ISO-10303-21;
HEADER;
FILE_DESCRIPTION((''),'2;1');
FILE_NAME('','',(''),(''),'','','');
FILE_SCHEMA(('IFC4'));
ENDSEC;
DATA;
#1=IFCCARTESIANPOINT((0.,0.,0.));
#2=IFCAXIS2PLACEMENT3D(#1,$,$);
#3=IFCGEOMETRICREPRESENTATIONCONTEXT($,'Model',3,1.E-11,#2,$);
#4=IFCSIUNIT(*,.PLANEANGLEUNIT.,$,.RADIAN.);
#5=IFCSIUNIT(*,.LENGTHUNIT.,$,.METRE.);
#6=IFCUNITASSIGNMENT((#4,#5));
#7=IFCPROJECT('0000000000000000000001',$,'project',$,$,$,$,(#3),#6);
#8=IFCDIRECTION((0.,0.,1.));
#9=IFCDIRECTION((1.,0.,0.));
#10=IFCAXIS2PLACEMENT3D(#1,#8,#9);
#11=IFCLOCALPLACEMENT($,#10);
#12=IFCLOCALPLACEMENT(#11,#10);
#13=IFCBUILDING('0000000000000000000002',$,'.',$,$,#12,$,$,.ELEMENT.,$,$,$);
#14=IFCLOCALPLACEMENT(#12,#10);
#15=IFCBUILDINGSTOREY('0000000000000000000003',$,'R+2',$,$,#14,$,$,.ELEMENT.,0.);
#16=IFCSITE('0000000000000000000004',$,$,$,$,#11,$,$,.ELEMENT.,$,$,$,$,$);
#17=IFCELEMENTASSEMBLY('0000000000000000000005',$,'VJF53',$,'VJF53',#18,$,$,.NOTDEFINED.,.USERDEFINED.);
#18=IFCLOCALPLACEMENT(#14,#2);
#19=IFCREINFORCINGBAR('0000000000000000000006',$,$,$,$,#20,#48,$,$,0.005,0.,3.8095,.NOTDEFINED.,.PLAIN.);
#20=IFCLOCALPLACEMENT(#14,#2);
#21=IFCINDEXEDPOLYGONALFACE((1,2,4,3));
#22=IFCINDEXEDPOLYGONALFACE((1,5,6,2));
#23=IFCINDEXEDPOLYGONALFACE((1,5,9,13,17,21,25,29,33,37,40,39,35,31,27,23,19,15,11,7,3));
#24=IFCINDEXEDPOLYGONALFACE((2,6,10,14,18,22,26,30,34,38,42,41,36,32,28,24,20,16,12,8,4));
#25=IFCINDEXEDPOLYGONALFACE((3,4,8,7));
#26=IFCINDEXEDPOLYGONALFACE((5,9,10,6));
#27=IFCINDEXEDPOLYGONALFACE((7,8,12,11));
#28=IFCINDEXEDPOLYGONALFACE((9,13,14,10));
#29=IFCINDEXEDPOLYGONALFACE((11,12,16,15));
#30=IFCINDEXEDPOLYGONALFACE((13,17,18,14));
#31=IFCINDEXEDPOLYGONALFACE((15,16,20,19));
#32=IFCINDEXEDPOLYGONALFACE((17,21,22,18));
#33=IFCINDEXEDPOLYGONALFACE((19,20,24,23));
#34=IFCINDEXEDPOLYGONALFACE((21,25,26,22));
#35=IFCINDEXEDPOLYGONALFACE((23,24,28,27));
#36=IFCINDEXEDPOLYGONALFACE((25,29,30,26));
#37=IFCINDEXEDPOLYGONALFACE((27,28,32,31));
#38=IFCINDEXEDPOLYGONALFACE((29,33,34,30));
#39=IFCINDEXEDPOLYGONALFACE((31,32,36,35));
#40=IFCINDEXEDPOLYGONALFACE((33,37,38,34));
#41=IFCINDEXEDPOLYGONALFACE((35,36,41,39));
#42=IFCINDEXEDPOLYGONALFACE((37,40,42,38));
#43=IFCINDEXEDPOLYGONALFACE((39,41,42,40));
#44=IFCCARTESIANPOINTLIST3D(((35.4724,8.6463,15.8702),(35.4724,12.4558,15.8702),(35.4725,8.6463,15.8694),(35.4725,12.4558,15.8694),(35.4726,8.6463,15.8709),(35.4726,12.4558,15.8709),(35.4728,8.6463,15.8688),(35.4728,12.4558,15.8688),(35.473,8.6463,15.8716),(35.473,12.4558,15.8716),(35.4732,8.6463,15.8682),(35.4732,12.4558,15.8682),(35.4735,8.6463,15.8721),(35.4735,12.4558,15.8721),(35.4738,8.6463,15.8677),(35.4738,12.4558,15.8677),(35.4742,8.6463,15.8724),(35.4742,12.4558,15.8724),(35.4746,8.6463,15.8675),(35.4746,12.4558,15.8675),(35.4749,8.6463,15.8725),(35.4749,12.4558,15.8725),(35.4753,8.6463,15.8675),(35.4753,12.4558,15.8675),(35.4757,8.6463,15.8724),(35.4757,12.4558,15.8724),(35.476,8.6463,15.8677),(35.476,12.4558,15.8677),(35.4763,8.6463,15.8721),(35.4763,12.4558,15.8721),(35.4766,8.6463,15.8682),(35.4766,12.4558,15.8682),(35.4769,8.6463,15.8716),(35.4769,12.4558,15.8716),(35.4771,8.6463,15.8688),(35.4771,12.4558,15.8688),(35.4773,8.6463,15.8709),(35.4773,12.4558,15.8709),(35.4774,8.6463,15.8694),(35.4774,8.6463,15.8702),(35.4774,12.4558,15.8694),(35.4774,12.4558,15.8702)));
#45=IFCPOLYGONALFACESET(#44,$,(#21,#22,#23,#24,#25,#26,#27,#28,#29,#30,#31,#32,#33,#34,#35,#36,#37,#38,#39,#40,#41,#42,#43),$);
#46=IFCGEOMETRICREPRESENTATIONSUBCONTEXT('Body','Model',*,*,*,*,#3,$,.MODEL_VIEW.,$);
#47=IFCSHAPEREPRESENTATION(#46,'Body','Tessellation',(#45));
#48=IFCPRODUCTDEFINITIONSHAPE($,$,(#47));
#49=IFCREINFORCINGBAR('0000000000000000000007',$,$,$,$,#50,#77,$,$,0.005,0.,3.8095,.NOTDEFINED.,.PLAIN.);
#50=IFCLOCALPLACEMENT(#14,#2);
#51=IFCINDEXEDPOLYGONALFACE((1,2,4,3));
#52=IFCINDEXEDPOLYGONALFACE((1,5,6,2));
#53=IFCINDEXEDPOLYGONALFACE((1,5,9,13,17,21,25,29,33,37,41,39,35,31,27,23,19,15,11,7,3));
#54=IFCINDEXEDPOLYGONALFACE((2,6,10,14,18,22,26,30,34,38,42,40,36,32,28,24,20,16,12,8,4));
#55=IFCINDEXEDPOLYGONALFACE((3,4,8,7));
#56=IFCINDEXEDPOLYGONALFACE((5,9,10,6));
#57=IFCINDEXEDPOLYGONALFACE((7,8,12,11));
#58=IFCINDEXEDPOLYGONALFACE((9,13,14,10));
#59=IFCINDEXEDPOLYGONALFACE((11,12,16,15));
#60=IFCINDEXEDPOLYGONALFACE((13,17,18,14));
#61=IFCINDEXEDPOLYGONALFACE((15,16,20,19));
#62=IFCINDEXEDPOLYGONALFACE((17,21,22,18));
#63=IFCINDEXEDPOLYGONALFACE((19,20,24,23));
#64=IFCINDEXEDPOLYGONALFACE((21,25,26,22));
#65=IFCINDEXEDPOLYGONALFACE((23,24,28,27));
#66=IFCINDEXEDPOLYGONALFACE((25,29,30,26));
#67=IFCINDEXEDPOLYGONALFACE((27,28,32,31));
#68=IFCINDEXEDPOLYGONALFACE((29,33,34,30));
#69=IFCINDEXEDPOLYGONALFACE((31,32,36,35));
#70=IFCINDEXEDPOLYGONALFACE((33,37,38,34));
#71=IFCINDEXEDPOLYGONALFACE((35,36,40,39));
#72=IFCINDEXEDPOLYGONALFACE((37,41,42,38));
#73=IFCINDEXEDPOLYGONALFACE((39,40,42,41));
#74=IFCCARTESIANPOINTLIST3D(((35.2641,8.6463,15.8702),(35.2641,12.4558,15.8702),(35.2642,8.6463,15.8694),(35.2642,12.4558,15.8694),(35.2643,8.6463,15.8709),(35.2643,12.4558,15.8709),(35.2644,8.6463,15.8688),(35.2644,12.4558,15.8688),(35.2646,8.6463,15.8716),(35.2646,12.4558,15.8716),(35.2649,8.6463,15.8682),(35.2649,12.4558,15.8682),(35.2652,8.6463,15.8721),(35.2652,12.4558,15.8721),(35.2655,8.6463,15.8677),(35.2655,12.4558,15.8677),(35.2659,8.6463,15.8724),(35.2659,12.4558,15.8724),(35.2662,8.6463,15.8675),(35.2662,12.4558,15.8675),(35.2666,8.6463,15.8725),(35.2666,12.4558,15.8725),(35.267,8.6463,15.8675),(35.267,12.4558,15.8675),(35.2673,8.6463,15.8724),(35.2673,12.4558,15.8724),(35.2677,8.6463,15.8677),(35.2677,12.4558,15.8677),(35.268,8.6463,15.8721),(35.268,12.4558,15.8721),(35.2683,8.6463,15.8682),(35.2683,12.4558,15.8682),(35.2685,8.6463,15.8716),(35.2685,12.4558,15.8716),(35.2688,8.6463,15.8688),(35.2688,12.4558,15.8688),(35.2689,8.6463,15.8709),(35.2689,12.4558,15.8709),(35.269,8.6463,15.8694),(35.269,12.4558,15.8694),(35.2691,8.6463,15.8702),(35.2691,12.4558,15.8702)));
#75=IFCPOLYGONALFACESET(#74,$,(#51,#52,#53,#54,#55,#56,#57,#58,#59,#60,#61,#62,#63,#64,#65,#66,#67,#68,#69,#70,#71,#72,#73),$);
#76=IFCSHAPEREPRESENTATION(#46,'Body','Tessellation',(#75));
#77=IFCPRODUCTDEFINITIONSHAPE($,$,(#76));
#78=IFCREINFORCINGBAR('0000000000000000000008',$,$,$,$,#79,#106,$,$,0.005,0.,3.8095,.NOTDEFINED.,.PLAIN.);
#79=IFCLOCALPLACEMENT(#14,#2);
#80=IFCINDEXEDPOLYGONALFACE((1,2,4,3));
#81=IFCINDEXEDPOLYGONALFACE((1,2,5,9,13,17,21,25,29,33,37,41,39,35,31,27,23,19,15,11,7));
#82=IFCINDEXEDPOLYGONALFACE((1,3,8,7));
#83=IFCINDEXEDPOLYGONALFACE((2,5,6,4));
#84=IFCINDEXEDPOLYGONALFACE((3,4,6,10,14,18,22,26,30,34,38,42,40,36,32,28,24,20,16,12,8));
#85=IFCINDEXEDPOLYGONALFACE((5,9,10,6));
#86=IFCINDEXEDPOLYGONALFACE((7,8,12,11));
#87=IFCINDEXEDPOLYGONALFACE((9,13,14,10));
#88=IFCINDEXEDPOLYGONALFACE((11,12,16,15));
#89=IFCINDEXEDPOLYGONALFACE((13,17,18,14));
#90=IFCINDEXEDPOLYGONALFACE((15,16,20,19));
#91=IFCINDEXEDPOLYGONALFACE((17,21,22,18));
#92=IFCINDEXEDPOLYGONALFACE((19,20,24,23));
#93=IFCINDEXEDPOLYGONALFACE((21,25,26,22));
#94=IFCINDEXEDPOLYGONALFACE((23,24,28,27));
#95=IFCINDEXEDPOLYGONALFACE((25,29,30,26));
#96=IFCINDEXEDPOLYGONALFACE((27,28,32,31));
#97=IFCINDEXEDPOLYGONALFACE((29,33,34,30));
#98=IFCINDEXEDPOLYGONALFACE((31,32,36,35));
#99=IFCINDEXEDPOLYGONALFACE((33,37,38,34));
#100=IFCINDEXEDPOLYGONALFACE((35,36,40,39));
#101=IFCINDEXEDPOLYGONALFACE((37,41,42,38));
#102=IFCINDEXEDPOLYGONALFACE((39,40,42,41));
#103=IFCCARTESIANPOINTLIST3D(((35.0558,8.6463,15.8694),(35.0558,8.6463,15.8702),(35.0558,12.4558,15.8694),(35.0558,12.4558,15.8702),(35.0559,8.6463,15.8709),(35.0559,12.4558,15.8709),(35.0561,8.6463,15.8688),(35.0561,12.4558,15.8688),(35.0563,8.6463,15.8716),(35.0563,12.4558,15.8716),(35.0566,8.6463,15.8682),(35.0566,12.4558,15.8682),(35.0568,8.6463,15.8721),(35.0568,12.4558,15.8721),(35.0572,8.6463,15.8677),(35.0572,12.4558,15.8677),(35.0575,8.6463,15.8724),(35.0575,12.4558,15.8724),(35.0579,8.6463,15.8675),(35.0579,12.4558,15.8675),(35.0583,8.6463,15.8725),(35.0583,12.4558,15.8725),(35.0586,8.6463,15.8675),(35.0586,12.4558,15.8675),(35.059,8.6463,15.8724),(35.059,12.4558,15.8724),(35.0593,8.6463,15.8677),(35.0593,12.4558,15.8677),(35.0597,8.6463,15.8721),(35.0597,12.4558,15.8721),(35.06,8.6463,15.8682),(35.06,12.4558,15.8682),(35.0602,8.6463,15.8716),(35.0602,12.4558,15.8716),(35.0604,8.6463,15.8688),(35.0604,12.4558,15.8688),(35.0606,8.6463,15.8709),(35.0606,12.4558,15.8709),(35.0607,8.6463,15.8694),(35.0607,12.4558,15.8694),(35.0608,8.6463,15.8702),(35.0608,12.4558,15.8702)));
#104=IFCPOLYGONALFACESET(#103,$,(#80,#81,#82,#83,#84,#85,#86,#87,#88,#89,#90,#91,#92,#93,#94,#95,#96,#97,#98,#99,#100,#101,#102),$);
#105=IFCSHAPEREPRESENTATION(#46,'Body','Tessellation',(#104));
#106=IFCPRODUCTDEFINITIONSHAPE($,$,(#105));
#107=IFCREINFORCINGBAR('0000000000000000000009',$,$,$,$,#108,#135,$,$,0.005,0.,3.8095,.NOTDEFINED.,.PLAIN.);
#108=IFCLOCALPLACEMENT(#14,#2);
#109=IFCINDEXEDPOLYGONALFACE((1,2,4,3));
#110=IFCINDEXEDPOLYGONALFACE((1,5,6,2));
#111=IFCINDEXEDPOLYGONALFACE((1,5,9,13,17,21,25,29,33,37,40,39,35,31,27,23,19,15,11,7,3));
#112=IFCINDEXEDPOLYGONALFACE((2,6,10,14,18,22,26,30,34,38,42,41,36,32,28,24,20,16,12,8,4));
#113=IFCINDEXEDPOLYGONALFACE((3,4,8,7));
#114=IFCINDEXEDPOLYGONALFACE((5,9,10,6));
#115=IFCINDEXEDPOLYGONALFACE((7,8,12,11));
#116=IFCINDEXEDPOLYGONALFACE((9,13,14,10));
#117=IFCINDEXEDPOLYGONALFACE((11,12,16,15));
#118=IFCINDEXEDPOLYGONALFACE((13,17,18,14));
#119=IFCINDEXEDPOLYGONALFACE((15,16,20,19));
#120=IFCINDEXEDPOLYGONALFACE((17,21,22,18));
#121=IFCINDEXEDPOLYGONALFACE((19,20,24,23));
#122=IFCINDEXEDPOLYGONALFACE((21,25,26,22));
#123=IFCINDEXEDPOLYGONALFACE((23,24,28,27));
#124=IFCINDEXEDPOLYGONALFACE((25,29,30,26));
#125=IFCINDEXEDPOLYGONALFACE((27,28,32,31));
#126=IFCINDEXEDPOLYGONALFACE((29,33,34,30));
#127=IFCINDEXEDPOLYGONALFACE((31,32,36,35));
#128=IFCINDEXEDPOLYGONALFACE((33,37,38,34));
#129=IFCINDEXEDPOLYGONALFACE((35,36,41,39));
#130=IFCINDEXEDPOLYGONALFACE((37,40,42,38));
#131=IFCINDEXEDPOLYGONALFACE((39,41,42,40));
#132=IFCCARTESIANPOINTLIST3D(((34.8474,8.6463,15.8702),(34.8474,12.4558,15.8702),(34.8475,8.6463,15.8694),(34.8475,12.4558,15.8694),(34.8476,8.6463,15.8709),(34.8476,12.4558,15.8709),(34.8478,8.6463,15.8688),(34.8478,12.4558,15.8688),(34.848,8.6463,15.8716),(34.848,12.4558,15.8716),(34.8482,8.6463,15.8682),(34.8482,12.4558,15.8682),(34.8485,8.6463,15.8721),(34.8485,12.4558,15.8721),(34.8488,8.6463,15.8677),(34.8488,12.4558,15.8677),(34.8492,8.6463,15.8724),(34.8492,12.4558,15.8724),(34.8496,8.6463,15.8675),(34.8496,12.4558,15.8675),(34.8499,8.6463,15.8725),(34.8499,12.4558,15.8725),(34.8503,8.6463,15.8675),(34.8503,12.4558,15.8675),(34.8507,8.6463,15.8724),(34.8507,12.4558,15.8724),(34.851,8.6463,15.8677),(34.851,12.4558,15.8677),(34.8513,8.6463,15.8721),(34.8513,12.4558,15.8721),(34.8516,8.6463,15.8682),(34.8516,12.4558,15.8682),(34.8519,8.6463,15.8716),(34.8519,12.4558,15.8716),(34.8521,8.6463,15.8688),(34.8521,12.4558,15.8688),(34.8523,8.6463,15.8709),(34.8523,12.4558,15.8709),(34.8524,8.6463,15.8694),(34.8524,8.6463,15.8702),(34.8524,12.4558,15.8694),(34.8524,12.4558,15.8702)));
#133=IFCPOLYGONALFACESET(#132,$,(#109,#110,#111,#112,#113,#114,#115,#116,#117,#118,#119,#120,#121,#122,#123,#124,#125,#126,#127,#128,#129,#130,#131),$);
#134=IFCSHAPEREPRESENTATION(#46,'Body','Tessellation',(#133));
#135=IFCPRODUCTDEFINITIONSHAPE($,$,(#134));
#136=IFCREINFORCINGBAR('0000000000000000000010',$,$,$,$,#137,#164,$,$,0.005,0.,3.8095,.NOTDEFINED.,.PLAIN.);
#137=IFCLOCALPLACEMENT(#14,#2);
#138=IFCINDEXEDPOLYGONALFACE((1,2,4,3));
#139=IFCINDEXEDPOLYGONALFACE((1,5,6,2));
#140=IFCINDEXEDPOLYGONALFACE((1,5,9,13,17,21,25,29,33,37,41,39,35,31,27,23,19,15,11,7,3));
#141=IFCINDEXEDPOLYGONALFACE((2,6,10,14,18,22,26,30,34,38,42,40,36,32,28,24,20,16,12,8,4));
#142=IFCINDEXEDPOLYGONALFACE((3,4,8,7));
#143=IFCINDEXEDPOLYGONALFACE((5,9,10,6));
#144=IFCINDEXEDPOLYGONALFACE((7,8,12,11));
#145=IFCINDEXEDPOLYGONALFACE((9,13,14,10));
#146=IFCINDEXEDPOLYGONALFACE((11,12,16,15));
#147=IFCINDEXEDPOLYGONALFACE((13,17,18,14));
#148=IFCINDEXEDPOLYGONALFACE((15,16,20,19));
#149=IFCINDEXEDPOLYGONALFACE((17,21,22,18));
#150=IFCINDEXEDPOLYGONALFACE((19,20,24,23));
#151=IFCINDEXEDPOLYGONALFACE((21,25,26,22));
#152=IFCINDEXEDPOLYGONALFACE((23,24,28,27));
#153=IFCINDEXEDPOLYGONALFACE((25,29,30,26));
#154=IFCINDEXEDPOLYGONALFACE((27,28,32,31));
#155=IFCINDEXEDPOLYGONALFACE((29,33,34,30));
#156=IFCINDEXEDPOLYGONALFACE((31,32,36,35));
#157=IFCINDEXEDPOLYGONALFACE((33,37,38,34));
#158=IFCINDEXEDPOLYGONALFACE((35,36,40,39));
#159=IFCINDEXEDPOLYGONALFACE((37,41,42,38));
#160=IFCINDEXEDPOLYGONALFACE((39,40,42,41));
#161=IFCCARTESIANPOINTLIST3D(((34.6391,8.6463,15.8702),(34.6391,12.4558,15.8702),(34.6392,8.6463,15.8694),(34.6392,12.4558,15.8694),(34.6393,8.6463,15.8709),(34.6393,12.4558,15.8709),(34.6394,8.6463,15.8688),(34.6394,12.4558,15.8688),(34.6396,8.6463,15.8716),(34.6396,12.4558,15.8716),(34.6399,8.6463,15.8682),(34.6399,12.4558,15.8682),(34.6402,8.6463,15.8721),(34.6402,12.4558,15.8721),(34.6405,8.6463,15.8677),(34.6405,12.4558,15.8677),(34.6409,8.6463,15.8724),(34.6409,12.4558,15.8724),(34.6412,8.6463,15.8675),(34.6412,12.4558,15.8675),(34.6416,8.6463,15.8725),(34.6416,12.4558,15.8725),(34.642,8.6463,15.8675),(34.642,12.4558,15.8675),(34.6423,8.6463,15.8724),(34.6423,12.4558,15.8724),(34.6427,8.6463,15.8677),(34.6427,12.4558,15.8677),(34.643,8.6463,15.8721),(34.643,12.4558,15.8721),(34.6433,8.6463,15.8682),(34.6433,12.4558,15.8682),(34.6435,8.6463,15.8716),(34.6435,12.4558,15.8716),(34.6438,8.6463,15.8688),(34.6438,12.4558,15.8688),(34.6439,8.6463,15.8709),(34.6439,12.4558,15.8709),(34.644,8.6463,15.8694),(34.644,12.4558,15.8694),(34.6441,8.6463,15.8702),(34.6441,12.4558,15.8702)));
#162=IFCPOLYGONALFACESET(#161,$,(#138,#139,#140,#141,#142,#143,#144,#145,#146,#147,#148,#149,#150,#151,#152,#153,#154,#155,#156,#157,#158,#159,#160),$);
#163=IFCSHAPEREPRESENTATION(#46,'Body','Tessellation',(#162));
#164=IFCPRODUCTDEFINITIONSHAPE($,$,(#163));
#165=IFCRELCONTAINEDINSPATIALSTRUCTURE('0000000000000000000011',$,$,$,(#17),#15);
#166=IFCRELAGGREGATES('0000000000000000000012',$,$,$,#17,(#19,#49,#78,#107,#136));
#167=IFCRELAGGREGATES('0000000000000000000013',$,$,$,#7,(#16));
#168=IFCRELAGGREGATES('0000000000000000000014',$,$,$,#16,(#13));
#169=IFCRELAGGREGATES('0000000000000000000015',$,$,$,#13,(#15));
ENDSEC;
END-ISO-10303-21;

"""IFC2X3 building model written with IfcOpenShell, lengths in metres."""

from ifc_helpers import new_model, entity, si_unit, origin, origin_with_axes, place, context, subcontext, project, spatial, shape, element, aggregate, save


model = new_model("IFC2X3")

# Units and contexts
model_context = context("Model", 3, precision=1e-11, world=origin())
body_context = subcontext(model_context, "Body", "Model", "MODEL_VIEW")
ifc_project = project(units=[si_unit("PLANEANGLEUNIT", "RADIAN"), si_unit("LENGTHUNIT", "METRE")], contexts=[model_context])

# Site, building, storey
site_placement = place(None, origin_with_axes())
site = spatial("IfcSite", under=ifc_project, at=site_placement, CompositionType="ELEMENT")
building_placement = place(site_placement, origin_with_axes())
building = spatial("IfcBuilding", under=site, at=building_placement, Name=".", CompositionType="ELEMENT")
storey_placement = place(building_placement, origin_with_axes())
storey = spatial("IfcBuildingStorey", under=building, at=storey_placement, Name="R+2", CompositionType="ELEMENT", Elevation=0.0)

# Element assembly, reinforcing bars
assembly_1_placement = place(storey_placement, origin_with_axes())
assembly_1 = element("IfcElementAssembly", 1, at=assembly_1_placement, inside=storey, Name="VJF53", ObjectType="VJF53", AssemblyPlace="NOTDEFINED", PredefinedType="USERDEFINED")
reinforcing_bar_1_placement = place(assembly_1_placement, origin_with_axes())
reinforcing_bar_1 = element("IfcReinforcingBar", 2, at=reinforcing_bar_1_placement, BarLength=3.8095, BarRole="NOTDEFINED", BarSurface="PLAIN", CrossSectionArea=0.0, NominalDiameter=0.005, shapes=[
    shape(body_context, "Body", "AdvancedSweptSolid", [entity("IfcSweptDiskSolid", entity("IfcPolyline", [entity("IfcCartesianPoint", [35.4749, 8.6463, 15.87]), entity("IfcCartesianPoint", [35.4749, 12.4558, 15.87])]), 0.0025, None, 0.0, 3.8095)]),
    shape(body_context, "Body", "AdvancedSweptSolid", [entity("IfcSweptDiskSolid", entity("IfcPolyline", [entity("IfcCartesianPoint", [35.4749, 8.6463, 15.87]), entity("IfcCartesianPoint", [35.4749, 12.4558, 15.87])]), 0.0025, None, 0.0, 3.8095)]),
])
reinforcing_bar_2_placement = place(assembly_1_placement, origin_with_axes())
reinforcing_bar_2 = element("IfcReinforcingBar", 3, at=reinforcing_bar_2_placement, BarLength=3.8095, BarRole="NOTDEFINED", BarSurface="PLAIN", CrossSectionArea=0.0, NominalDiameter=0.005, shapes=[
    shape(body_context, "Body", "AdvancedSweptSolid", [entity("IfcSweptDiskSolid", entity("IfcPolyline", [entity("IfcCartesianPoint", [35.2666, 8.6463, 15.87]), entity("IfcCartesianPoint", [35.2666, 12.4558, 15.87])]), 0.0025, None, 0.0, 3.8095)]),
    shape(body_context, "Body", "AdvancedSweptSolid", [entity("IfcSweptDiskSolid", entity("IfcPolyline", [entity("IfcCartesianPoint", [35.2666, 8.6463, 15.87]), entity("IfcCartesianPoint", [35.2666, 12.4558, 15.87])]), 0.0025, None, 0.0, 3.8095)]),
])
reinforcing_bar_3_placement = place(assembly_1_placement, origin_with_axes())
reinforcing_bar_3 = element("IfcReinforcingBar", 4, at=reinforcing_bar_3_placement, BarLength=3.8095, BarRole="NOTDEFINED", BarSurface="PLAIN", CrossSectionArea=0.0, NominalDiameter=0.005, shapes=[
    shape(body_context, "Body", "AdvancedSweptSolid", [entity("IfcSweptDiskSolid", entity("IfcPolyline", [entity("IfcCartesianPoint", [35.0583, 8.6463, 15.87]), entity("IfcCartesianPoint", [35.0583, 12.4558, 15.87])]), 0.0025, None, 0.0, 3.8095)]),
    shape(body_context, "Body", "AdvancedSweptSolid", [entity("IfcSweptDiskSolid", entity("IfcPolyline", [entity("IfcCartesianPoint", [35.0583, 8.6463, 15.87]), entity("IfcCartesianPoint", [35.0583, 12.4558, 15.87])]), 0.0025, None, 0.0, 3.8095)]),
])
reinforcing_bar_4_placement = place(assembly_1_placement, origin_with_axes())
reinforcing_bar_4 = element("IfcReinforcingBar", 5, at=reinforcing_bar_4_placement, BarLength=3.8095, BarRole="NOTDEFINED", BarSurface="PLAIN", CrossSectionArea=0.0, NominalDiameter=0.005, shapes=[
    shape(body_context, "Body", "AdvancedSweptSolid", [entity("IfcSweptDiskSolid", entity("IfcPolyline", [entity("IfcCartesianPoint", [34.8499, 8.6463, 15.87]), entity("IfcCartesianPoint", [34.8499, 12.4558, 15.87])]), 0.0025, None, 0.0, 3.8095)]),
    shape(body_context, "Body", "AdvancedSweptSolid", [entity("IfcSweptDiskSolid", entity("IfcPolyline", [entity("IfcCartesianPoint", [34.8499, 8.6463, 15.87]), entity("IfcCartesianPoint", [34.8499, 12.4558, 15.87])]), 0.0025, None, 0.0, 3.8095)]),
])
reinforcing_bar_5_placement = place(assembly_1_placement, origin_with_axes())
reinforcing_bar_5 = element("IfcReinforcingBar", 6, at=reinforcing_bar_5_placement, BarLength=3.8095, BarRole="NOTDEFINED", BarSurface="PLAIN", CrossSectionArea=0.0, NominalDiameter=0.005, shapes=[
    shape(body_context, "Body", "AdvancedSweptSolid", [entity("IfcSweptDiskSolid", entity("IfcPolyline", [entity("IfcCartesianPoint", [34.6416, 8.6463, 15.87]), entity("IfcCartesianPoint", [34.6416, 12.4558, 15.87])]), 0.0025, None, 0.0, 3.8095)]),
    shape(body_context, "Body", "AdvancedSweptSolid", [entity("IfcSweptDiskSolid", entity("IfcPolyline", [entity("IfcCartesianPoint", [34.6416, 8.6463, 15.87]), entity("IfcCartesianPoint", [34.6416, 12.4558, 15.87])]), 0.0025, None, 0.0, 3.8095)]),
])
aggregate(assembly_1, [reinforcing_bar_1, reinforcing_bar_2, reinforcing_bar_3, reinforcing_bar_4, reinforcing_bar_5])

save(model, "model.ifc")
